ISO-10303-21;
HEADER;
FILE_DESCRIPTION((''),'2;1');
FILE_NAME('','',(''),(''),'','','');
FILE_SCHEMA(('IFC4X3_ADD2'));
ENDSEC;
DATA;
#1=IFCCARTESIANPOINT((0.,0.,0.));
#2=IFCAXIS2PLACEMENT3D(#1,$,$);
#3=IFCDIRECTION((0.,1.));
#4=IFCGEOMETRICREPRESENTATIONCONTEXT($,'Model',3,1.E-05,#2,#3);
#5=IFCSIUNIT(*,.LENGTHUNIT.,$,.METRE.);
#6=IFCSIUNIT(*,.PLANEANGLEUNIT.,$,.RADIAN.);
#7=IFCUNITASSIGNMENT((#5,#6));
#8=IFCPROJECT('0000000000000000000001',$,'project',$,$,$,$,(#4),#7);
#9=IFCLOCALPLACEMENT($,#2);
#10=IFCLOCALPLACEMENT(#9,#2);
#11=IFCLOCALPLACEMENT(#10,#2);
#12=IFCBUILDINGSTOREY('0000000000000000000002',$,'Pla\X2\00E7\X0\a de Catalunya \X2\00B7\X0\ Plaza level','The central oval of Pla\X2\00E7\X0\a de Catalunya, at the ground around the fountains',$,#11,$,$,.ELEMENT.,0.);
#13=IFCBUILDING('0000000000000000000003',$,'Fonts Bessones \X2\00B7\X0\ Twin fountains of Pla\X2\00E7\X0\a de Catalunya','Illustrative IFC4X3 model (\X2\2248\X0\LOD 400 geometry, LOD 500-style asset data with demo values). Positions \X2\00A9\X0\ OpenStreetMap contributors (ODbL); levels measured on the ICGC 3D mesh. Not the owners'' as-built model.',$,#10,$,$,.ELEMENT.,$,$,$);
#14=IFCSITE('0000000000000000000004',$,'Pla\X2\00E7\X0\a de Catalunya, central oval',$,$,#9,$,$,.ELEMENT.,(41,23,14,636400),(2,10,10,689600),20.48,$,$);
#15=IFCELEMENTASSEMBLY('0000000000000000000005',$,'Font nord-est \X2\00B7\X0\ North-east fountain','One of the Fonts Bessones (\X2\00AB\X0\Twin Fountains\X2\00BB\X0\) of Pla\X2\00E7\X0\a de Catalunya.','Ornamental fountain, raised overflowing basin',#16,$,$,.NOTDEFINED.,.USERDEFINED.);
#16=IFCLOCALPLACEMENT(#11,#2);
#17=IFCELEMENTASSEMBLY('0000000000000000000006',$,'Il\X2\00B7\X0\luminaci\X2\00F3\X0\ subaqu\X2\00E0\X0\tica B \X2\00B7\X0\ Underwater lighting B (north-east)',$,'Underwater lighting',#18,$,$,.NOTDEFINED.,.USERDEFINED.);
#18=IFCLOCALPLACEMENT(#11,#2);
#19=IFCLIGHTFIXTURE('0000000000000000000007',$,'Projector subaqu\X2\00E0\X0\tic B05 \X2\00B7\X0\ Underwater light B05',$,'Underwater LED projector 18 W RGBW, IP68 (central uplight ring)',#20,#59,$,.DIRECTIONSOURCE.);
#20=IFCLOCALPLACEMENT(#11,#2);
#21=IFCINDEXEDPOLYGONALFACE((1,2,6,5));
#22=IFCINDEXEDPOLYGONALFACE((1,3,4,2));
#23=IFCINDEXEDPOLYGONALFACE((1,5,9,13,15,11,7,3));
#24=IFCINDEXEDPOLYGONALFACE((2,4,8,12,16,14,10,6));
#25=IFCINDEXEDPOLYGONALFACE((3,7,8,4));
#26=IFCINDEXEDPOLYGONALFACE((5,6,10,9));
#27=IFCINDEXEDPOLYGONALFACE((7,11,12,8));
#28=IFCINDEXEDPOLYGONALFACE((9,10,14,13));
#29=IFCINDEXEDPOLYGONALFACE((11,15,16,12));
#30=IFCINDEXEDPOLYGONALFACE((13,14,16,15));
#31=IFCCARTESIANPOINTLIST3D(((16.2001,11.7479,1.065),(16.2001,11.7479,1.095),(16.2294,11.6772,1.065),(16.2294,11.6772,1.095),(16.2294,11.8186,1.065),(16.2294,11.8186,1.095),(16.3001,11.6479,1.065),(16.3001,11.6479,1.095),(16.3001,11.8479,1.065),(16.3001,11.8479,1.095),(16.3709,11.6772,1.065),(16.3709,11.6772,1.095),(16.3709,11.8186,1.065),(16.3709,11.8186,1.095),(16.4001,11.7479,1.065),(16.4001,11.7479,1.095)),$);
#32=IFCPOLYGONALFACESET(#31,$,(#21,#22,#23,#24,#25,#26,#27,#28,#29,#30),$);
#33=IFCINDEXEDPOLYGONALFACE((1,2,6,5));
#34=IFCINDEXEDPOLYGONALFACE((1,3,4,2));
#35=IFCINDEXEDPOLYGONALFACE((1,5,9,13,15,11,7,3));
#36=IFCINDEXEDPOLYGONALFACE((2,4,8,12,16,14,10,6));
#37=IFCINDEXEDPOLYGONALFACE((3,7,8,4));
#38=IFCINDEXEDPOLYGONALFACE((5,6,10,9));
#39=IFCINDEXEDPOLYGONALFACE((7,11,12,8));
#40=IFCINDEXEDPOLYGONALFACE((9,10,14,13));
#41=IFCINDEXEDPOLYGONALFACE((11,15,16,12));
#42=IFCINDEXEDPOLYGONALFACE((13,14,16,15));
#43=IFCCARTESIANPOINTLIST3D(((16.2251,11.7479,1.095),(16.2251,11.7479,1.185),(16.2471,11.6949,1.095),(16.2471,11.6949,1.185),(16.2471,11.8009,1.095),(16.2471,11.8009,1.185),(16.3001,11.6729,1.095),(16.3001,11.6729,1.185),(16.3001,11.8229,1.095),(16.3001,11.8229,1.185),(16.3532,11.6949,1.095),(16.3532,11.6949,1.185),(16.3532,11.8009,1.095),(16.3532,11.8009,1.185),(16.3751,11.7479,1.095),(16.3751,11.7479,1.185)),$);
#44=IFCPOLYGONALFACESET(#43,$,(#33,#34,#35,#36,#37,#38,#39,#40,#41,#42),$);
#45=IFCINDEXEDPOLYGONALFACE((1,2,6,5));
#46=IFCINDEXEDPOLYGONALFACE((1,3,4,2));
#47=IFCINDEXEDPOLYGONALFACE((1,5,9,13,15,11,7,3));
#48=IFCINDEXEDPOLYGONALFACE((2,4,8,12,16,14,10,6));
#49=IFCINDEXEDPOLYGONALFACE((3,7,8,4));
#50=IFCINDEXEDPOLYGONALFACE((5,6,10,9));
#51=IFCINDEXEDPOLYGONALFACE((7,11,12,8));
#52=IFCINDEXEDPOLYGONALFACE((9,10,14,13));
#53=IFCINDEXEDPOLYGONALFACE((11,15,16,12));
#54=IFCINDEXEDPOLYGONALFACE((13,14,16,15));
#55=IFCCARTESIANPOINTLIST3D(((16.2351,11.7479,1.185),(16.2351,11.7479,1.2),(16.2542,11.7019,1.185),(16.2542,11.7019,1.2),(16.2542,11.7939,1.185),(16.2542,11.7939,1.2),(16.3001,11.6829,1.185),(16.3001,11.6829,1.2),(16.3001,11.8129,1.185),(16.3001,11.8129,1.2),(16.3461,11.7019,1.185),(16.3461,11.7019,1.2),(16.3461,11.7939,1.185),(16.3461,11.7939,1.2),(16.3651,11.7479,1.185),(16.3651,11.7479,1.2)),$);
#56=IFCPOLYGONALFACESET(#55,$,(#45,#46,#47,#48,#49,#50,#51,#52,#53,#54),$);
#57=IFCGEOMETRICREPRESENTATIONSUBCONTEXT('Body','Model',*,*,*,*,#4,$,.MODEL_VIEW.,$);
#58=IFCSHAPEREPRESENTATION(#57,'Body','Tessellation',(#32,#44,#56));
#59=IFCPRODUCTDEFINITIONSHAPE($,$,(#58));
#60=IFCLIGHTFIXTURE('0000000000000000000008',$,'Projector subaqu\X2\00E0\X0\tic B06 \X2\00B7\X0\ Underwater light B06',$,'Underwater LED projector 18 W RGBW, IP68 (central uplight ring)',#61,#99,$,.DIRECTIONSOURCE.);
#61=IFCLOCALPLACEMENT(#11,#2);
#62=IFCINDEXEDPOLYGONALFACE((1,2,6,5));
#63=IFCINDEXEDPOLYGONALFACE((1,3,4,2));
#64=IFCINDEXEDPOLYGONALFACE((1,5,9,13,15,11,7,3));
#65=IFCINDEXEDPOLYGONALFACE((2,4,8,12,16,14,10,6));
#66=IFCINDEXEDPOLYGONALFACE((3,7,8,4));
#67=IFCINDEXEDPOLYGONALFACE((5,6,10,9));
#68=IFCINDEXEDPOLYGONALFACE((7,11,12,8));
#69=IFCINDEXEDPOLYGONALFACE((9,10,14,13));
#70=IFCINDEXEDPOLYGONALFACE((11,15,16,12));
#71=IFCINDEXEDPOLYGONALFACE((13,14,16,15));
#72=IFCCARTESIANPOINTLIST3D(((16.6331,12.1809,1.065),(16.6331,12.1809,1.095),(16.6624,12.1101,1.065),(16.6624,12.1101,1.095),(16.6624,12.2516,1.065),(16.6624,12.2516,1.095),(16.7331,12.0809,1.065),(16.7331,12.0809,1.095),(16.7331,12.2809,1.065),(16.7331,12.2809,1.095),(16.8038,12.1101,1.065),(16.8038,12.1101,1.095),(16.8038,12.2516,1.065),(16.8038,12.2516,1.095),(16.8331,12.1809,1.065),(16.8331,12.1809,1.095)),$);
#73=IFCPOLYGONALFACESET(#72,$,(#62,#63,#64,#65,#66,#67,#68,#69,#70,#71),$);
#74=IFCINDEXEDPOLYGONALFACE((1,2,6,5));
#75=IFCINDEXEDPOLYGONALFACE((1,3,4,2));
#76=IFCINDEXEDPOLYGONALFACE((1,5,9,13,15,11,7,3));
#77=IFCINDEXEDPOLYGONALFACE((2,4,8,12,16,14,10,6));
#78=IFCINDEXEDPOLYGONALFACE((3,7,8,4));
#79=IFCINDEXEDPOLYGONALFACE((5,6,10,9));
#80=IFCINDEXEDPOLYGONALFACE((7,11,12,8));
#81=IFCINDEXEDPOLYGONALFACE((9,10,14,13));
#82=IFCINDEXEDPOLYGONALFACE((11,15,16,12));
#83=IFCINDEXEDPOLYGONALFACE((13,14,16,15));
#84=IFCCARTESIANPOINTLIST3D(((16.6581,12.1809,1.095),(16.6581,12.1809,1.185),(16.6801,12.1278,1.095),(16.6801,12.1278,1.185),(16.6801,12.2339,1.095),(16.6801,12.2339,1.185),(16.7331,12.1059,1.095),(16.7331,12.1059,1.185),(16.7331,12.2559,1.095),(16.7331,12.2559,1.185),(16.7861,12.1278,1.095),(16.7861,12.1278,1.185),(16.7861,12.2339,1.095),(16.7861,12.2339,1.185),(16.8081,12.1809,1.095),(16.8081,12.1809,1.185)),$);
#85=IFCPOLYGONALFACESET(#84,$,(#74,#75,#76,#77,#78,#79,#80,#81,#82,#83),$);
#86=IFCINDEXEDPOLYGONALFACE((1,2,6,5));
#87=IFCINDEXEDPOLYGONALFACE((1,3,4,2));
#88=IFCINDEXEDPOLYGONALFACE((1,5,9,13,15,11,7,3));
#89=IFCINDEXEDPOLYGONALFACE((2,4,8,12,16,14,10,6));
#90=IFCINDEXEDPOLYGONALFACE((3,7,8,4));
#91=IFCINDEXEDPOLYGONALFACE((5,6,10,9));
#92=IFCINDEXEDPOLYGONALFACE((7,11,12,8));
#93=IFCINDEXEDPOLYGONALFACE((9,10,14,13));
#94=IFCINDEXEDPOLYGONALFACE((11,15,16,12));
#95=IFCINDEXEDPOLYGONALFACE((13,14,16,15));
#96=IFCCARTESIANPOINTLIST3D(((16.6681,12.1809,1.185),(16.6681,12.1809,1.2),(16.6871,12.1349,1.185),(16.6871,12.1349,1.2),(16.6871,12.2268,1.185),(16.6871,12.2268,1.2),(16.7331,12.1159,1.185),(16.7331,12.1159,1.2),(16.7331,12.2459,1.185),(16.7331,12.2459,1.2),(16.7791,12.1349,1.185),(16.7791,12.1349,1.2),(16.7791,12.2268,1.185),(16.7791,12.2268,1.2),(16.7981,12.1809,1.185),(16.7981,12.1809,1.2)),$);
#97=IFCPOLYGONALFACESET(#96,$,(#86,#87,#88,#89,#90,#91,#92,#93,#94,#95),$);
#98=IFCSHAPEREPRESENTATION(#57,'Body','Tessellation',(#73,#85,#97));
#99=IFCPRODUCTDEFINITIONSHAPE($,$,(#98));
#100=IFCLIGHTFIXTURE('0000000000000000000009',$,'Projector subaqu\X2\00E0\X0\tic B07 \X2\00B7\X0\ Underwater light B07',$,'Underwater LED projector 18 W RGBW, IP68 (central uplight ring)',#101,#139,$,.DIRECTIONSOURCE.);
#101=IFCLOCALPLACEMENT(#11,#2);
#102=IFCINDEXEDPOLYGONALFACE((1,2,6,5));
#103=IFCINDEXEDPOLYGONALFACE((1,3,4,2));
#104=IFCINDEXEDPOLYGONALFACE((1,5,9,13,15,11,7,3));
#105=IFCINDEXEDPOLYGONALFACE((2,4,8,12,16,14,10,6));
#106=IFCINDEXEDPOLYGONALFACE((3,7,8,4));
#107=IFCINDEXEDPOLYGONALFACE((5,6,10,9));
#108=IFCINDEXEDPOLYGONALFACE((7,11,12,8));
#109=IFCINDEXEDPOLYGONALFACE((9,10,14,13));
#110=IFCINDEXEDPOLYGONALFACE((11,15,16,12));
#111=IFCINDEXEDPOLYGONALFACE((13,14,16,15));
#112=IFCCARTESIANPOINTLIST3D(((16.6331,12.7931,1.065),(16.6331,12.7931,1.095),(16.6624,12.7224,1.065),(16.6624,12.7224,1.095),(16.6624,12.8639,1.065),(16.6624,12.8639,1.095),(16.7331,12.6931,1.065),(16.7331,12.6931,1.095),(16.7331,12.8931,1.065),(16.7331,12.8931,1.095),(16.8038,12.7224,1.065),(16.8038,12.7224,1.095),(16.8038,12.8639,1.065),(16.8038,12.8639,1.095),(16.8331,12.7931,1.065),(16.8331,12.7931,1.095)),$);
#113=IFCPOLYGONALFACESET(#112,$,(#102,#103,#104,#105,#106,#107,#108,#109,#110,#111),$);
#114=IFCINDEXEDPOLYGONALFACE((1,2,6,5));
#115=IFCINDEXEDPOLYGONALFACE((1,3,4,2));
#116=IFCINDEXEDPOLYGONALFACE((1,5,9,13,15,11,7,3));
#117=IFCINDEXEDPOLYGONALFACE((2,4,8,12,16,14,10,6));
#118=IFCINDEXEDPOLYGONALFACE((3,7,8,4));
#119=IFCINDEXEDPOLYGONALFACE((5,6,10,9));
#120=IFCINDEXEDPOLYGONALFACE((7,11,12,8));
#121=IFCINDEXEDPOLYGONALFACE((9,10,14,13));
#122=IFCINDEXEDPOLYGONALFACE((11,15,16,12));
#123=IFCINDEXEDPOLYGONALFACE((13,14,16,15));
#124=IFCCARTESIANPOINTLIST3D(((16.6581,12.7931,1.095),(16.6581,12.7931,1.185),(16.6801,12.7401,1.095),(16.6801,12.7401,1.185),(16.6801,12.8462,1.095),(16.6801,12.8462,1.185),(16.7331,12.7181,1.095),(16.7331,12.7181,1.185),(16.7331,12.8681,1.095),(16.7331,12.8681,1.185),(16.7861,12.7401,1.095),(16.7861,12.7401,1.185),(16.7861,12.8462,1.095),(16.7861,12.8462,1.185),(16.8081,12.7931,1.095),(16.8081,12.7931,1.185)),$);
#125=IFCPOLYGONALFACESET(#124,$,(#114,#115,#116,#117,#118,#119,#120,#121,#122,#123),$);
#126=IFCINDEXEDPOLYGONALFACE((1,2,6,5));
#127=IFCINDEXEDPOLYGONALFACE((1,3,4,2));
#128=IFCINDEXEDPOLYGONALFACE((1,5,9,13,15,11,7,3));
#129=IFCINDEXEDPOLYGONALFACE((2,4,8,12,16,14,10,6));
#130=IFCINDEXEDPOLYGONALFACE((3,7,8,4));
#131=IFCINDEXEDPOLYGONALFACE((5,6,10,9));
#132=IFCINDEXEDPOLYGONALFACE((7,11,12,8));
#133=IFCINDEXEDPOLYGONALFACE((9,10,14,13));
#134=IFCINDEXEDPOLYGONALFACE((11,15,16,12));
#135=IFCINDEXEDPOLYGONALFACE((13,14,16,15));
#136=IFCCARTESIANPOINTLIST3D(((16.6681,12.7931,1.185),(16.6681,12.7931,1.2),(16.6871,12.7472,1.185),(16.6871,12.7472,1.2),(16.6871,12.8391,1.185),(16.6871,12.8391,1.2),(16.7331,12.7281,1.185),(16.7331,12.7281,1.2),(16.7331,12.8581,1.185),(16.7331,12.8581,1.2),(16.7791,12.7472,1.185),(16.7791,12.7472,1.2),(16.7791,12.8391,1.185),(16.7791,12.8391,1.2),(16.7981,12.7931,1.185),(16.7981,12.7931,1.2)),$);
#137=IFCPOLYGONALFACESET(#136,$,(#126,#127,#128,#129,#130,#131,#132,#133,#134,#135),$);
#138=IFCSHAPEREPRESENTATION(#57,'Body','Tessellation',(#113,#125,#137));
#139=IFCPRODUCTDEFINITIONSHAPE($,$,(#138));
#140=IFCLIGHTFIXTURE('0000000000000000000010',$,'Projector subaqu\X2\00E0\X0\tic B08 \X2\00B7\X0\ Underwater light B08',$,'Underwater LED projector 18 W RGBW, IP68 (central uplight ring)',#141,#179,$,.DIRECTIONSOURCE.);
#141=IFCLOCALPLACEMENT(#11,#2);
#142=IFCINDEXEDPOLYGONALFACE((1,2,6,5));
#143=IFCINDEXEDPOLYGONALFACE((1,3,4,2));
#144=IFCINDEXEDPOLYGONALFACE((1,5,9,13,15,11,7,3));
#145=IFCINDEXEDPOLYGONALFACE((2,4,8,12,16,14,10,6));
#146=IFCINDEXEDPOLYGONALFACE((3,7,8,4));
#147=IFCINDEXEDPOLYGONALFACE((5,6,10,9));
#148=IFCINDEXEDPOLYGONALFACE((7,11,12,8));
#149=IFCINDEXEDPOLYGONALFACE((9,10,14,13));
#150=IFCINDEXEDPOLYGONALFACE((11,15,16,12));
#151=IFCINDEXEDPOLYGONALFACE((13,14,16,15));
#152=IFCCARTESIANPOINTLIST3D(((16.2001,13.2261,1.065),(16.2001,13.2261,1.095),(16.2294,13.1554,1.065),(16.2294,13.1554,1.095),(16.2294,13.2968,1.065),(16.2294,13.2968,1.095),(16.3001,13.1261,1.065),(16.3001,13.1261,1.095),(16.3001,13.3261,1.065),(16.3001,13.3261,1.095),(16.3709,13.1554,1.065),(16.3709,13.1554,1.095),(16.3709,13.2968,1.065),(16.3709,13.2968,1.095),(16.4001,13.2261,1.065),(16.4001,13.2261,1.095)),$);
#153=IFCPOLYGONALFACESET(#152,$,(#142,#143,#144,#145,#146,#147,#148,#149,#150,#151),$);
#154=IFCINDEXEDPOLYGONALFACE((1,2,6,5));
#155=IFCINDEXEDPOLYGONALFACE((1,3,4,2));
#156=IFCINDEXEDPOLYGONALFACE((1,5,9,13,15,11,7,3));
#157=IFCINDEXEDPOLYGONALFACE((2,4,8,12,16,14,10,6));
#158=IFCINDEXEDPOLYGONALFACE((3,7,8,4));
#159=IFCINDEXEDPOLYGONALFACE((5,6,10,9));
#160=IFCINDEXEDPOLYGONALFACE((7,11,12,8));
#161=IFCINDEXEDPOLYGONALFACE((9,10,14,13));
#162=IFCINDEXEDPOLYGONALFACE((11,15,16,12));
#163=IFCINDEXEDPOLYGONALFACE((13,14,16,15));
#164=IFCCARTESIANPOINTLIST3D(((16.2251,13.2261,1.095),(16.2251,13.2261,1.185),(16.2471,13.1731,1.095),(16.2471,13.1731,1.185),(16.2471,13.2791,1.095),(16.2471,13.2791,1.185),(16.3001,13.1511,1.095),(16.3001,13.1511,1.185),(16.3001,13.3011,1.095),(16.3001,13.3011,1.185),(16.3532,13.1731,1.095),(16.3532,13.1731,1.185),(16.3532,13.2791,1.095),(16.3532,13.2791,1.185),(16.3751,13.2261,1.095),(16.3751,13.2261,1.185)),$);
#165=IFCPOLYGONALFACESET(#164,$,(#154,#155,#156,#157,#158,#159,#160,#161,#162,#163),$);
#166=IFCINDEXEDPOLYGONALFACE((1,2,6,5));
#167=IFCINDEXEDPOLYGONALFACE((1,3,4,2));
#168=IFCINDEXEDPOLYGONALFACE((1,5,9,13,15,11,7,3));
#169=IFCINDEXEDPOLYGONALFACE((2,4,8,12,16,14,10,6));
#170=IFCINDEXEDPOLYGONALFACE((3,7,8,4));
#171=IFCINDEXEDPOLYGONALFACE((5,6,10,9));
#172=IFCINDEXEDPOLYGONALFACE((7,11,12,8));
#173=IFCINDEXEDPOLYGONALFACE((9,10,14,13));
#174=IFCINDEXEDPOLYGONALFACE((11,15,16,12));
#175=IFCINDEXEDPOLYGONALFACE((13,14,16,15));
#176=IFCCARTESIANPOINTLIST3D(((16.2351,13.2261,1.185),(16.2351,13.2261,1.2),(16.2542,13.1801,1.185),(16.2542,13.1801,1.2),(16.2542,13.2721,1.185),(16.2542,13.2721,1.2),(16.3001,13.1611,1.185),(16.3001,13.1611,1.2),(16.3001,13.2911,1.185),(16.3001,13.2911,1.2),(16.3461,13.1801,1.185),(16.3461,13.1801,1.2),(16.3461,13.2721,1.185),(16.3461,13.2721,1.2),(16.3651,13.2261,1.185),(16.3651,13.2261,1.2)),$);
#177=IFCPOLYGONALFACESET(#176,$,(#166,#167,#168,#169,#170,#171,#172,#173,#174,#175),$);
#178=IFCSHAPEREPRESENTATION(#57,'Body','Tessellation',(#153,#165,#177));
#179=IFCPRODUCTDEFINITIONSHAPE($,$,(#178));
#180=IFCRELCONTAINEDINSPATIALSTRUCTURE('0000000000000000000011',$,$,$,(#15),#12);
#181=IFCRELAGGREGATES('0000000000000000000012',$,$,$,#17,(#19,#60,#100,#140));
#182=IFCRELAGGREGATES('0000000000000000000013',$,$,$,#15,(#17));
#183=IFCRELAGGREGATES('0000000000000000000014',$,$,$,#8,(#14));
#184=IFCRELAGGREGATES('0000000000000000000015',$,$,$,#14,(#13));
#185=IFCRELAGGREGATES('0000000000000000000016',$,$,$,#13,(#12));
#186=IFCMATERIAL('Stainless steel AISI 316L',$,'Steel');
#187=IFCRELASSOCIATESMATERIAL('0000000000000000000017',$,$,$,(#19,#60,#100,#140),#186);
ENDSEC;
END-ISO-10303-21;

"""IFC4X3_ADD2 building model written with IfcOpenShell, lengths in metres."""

from ifc_helpers import new_model, si_unit, direction, frame, origin, place, context, subcontext, project, spatial, polyline, outline, extrude, material, element, aggregate, save


model = new_model("IFC4X3_ADD2")

# Units and contexts
model_context = context("Model", 3, precision=1e-05, world=origin(), true_north=direction((0.0, 1.0)))
body_context = subcontext(model_context, "Body", "Model", "MODEL_VIEW")
ifc_project = project(units=[si_unit("LENGTHUNIT", "METRE"), si_unit("PLANEANGLEUNIT", "RADIAN")], contexts=[model_context])

# Site, building, storey
site_placement = place(None, origin())
site = spatial("IfcSite", under=ifc_project, at=site_placement, Name="Plaça de Catalunya, central oval", CompositionType="ELEMENT", RefLatitude=(41, 23, 14, 636400), RefLongitude=(2, 10, 10, 689600), RefElevation=20.48)
building_placement = place(site_placement, origin())
building = spatial("IfcBuilding", under=site, at=building_placement, Name="Fonts Bessones · Twin fountains of Plaça de Catalunya", Description="Illustrative IFC4X3 model (≈LOD 400 geometry, LOD 500-style asset data with demo values). Positions © OpenStreetMap contributors (ODbL); levels measured on the ICGC 3D mesh. Not the owners' as-built model.", CompositionType="ELEMENT")
storey_placement = place(building_placement, origin())
storey = spatial("IfcBuildingStorey", under=building, at=storey_placement, Name="Plaça de Catalunya · Plaza level", Description="The central oval of Plaça de Catalunya, at the ground around the fountains", CompositionType="ELEMENT", Elevation=0.0)

# Element assemblies, light fixtures
assembly_1_placement = place(building_placement, origin())
assembly_1 = element("IfcElementAssembly", 1, at=assembly_1_placement, inside=storey, Name="Font nord-est · North-east fountain", Description="One of the Fonts Bessones («Twin Fountains») of Plaça de Catalunya.", ObjectType="Ornamental fountain, raised overflowing basin", AssemblyPlace="NOTDEFINED", PredefinedType="USERDEFINED")
assembly_2_placement = place(building_placement, origin())
assembly_2 = element("IfcElementAssembly", 2, at=assembly_2_placement, Name="Il·luminació subaquàtica B · Underwater lighting B (north-east)", ObjectType="Underwater lighting", AssemblyPlace="NOTDEFINED", PredefinedType="USERDEFINED")
ifc_material_1 = material(Name="Stainless steel AISI 316L", Category="Steel")
light_fixture_1_placement = place(building_placement, origin())
light_fixture_1 = element("IfcLightFixture", 3, at=light_fixture_1_placement, material=ifc_material_1, Name="Projector subaquàtic B05 · Underwater light B05", ObjectType="Underwater LED projector 18 W RGBW, IP68 (central uplight ring)", PredefinedType="DIRECTIONSOURCE", context=body_context, shape_type="SweptSolid", body=[
    extrude(outline(polyline([(16.4001, 11.7479), (16.3709, 11.8186), (16.3001, 11.8479), (16.2294, 11.8186), (16.2001, 11.7479), (16.2294, 11.6772), (16.3001, 11.6479), (16.3709, 11.6772), (16.4001, 11.7479)])), frame((0.0, 0.0, 1.065)), (0.0, 0.0, 1.0), 0.03),
    extrude(outline(polyline([(16.3751, 11.7479), (16.3532, 11.8009), (16.3001, 11.8229), (16.2471, 11.8009), (16.2251, 11.7479), (16.2471, 11.6949), (16.3001, 11.6729), (16.3532, 11.6949), (16.3751, 11.7479)])), frame((0.0, 0.0, 1.095)), (0.0, 0.0, 1.0), 0.09),
    extrude(outline(polyline([(16.3651, 11.7479), (16.3461, 11.7939), (16.3001, 11.8129), (16.2542, 11.7939), (16.2351, 11.7479), (16.2542, 11.7019), (16.3001, 11.6829), (16.3461, 11.7019), (16.3651, 11.7479)])), frame((0.0, 0.0, 1.185)), (0.0, 0.0, 1.0), 0.015),
])
light_fixture_2_placement = place(building_placement, origin())
light_fixture_2 = element("IfcLightFixture", 4, at=light_fixture_2_placement, material=ifc_material_1, Name="Projector subaquàtic B06 · Underwater light B06", ObjectType="Underwater LED projector 18 W RGBW, IP68 (central uplight ring)", PredefinedType="DIRECTIONSOURCE", context=body_context, shape_type="SweptSolid", body=[
    extrude(outline(polyline([(16.8331, 12.1809), (16.8038, 12.2516), (16.7331, 12.2809), (16.6624, 12.2516), (16.6331, 12.1809), (16.6624, 12.1101), (16.7331, 12.0809), (16.8038, 12.1101), (16.8331, 12.1809)])), frame((0.0, 0.0, 1.065)), (0.0, 0.0, 1.0), 0.03),
    extrude(outline(polyline([(16.8081, 12.1809), (16.7861, 12.2339), (16.7331, 12.2559), (16.6801, 12.2339), (16.6581, 12.1809), (16.6801, 12.1278), (16.7331, 12.1059), (16.7861, 12.1278), (16.8081, 12.1809)])), frame((0.0, 0.0, 1.095)), (0.0, 0.0, 1.0), 0.09),
    extrude(outline(polyline([(16.7981, 12.1809), (16.7791, 12.2268), (16.7331, 12.2459), (16.6871, 12.2268), (16.6681, 12.1809), (16.6871, 12.1349), (16.7331, 12.1159), (16.7791, 12.1349), (16.7981, 12.1809)])), frame((0.0, 0.0, 1.185)), (0.0, 0.0, 1.0), 0.015),
])
light_fixture_3_placement = place(building_placement, origin())
light_fixture_3 = element("IfcLightFixture", 5, at=light_fixture_3_placement, material=ifc_material_1, Name="Projector subaquàtic B07 · Underwater light B07", ObjectType="Underwater LED projector 18 W RGBW, IP68 (central uplight ring)", PredefinedType="DIRECTIONSOURCE", context=body_context, shape_type="SweptSolid", body=[
    extrude(outline(polyline([(16.8331, 12.7931), (16.8038, 12.8639), (16.7331, 12.8931), (16.6624, 12.8639), (16.6331, 12.7931), (16.6624, 12.7224), (16.7331, 12.6931), (16.8038, 12.7224), (16.8331, 12.7931)])), frame((0.0, 0.0, 1.065)), (0.0, 0.0, 1.0), 0.03),
    extrude(outline(polyline([(16.8081, 12.7931), (16.7861, 12.8462), (16.7331, 12.8681), (16.6801, 12.8462), (16.6581, 12.7931), (16.6801, 12.7401), (16.7331, 12.7181), (16.7861, 12.7401), (16.8081, 12.7931)])), frame((0.0, 0.0, 1.095)), (0.0, 0.0, 1.0), 0.09),
    extrude(outline(polyline([(16.7981, 12.7931), (16.7791, 12.8391), (16.7331, 12.8581), (16.6871, 12.8391), (16.6681, 12.7931), (16.6871, 12.7472), (16.7331, 12.7281), (16.7791, 12.7472), (16.7981, 12.7931)])), frame((0.0, 0.0, 1.185)), (0.0, 0.0, 1.0), 0.015),
])
light_fixture_4_placement = place(building_placement, origin())
light_fixture_4 = element("IfcLightFixture", 6, at=light_fixture_4_placement, material=ifc_material_1, Name="Projector subaquàtic B08 · Underwater light B08", ObjectType="Underwater LED projector 18 W RGBW, IP68 (central uplight ring)", PredefinedType="DIRECTIONSOURCE", context=body_context, shape_type="SweptSolid", body=[
    extrude(outline(polyline([(16.4001, 13.2261), (16.3709, 13.2968), (16.3001, 13.3261), (16.2294, 13.2968), (16.2001, 13.2261), (16.2294, 13.1554), (16.3001, 13.1261), (16.3709, 13.1554), (16.4001, 13.2261)])), frame((0.0, 0.0, 1.065)), (0.0, 0.0, 1.0), 0.03),
    extrude(outline(polyline([(16.3751, 13.2261), (16.3532, 13.2791), (16.3001, 13.3011), (16.2471, 13.2791), (16.2251, 13.2261), (16.2471, 13.1731), (16.3001, 13.1511), (16.3532, 13.1731), (16.3751, 13.2261)])), frame((0.0, 0.0, 1.095)), (0.0, 0.0, 1.0), 0.09),
    extrude(outline(polyline([(16.3651, 13.2261), (16.3461, 13.2721), (16.3001, 13.2911), (16.2542, 13.2721), (16.2351, 13.2261), (16.2542, 13.1801), (16.3001, 13.1611), (16.3461, 13.1801), (16.3651, 13.2261)])), frame((0.0, 0.0, 1.185)), (0.0, 0.0, 1.0), 0.015),
])
aggregate(assembly_2, [light_fixture_1, light_fixture_2, light_fixture_3, light_fixture_4])
aggregate(assembly_1, [assembly_2])

save(model, "model.ifc")
